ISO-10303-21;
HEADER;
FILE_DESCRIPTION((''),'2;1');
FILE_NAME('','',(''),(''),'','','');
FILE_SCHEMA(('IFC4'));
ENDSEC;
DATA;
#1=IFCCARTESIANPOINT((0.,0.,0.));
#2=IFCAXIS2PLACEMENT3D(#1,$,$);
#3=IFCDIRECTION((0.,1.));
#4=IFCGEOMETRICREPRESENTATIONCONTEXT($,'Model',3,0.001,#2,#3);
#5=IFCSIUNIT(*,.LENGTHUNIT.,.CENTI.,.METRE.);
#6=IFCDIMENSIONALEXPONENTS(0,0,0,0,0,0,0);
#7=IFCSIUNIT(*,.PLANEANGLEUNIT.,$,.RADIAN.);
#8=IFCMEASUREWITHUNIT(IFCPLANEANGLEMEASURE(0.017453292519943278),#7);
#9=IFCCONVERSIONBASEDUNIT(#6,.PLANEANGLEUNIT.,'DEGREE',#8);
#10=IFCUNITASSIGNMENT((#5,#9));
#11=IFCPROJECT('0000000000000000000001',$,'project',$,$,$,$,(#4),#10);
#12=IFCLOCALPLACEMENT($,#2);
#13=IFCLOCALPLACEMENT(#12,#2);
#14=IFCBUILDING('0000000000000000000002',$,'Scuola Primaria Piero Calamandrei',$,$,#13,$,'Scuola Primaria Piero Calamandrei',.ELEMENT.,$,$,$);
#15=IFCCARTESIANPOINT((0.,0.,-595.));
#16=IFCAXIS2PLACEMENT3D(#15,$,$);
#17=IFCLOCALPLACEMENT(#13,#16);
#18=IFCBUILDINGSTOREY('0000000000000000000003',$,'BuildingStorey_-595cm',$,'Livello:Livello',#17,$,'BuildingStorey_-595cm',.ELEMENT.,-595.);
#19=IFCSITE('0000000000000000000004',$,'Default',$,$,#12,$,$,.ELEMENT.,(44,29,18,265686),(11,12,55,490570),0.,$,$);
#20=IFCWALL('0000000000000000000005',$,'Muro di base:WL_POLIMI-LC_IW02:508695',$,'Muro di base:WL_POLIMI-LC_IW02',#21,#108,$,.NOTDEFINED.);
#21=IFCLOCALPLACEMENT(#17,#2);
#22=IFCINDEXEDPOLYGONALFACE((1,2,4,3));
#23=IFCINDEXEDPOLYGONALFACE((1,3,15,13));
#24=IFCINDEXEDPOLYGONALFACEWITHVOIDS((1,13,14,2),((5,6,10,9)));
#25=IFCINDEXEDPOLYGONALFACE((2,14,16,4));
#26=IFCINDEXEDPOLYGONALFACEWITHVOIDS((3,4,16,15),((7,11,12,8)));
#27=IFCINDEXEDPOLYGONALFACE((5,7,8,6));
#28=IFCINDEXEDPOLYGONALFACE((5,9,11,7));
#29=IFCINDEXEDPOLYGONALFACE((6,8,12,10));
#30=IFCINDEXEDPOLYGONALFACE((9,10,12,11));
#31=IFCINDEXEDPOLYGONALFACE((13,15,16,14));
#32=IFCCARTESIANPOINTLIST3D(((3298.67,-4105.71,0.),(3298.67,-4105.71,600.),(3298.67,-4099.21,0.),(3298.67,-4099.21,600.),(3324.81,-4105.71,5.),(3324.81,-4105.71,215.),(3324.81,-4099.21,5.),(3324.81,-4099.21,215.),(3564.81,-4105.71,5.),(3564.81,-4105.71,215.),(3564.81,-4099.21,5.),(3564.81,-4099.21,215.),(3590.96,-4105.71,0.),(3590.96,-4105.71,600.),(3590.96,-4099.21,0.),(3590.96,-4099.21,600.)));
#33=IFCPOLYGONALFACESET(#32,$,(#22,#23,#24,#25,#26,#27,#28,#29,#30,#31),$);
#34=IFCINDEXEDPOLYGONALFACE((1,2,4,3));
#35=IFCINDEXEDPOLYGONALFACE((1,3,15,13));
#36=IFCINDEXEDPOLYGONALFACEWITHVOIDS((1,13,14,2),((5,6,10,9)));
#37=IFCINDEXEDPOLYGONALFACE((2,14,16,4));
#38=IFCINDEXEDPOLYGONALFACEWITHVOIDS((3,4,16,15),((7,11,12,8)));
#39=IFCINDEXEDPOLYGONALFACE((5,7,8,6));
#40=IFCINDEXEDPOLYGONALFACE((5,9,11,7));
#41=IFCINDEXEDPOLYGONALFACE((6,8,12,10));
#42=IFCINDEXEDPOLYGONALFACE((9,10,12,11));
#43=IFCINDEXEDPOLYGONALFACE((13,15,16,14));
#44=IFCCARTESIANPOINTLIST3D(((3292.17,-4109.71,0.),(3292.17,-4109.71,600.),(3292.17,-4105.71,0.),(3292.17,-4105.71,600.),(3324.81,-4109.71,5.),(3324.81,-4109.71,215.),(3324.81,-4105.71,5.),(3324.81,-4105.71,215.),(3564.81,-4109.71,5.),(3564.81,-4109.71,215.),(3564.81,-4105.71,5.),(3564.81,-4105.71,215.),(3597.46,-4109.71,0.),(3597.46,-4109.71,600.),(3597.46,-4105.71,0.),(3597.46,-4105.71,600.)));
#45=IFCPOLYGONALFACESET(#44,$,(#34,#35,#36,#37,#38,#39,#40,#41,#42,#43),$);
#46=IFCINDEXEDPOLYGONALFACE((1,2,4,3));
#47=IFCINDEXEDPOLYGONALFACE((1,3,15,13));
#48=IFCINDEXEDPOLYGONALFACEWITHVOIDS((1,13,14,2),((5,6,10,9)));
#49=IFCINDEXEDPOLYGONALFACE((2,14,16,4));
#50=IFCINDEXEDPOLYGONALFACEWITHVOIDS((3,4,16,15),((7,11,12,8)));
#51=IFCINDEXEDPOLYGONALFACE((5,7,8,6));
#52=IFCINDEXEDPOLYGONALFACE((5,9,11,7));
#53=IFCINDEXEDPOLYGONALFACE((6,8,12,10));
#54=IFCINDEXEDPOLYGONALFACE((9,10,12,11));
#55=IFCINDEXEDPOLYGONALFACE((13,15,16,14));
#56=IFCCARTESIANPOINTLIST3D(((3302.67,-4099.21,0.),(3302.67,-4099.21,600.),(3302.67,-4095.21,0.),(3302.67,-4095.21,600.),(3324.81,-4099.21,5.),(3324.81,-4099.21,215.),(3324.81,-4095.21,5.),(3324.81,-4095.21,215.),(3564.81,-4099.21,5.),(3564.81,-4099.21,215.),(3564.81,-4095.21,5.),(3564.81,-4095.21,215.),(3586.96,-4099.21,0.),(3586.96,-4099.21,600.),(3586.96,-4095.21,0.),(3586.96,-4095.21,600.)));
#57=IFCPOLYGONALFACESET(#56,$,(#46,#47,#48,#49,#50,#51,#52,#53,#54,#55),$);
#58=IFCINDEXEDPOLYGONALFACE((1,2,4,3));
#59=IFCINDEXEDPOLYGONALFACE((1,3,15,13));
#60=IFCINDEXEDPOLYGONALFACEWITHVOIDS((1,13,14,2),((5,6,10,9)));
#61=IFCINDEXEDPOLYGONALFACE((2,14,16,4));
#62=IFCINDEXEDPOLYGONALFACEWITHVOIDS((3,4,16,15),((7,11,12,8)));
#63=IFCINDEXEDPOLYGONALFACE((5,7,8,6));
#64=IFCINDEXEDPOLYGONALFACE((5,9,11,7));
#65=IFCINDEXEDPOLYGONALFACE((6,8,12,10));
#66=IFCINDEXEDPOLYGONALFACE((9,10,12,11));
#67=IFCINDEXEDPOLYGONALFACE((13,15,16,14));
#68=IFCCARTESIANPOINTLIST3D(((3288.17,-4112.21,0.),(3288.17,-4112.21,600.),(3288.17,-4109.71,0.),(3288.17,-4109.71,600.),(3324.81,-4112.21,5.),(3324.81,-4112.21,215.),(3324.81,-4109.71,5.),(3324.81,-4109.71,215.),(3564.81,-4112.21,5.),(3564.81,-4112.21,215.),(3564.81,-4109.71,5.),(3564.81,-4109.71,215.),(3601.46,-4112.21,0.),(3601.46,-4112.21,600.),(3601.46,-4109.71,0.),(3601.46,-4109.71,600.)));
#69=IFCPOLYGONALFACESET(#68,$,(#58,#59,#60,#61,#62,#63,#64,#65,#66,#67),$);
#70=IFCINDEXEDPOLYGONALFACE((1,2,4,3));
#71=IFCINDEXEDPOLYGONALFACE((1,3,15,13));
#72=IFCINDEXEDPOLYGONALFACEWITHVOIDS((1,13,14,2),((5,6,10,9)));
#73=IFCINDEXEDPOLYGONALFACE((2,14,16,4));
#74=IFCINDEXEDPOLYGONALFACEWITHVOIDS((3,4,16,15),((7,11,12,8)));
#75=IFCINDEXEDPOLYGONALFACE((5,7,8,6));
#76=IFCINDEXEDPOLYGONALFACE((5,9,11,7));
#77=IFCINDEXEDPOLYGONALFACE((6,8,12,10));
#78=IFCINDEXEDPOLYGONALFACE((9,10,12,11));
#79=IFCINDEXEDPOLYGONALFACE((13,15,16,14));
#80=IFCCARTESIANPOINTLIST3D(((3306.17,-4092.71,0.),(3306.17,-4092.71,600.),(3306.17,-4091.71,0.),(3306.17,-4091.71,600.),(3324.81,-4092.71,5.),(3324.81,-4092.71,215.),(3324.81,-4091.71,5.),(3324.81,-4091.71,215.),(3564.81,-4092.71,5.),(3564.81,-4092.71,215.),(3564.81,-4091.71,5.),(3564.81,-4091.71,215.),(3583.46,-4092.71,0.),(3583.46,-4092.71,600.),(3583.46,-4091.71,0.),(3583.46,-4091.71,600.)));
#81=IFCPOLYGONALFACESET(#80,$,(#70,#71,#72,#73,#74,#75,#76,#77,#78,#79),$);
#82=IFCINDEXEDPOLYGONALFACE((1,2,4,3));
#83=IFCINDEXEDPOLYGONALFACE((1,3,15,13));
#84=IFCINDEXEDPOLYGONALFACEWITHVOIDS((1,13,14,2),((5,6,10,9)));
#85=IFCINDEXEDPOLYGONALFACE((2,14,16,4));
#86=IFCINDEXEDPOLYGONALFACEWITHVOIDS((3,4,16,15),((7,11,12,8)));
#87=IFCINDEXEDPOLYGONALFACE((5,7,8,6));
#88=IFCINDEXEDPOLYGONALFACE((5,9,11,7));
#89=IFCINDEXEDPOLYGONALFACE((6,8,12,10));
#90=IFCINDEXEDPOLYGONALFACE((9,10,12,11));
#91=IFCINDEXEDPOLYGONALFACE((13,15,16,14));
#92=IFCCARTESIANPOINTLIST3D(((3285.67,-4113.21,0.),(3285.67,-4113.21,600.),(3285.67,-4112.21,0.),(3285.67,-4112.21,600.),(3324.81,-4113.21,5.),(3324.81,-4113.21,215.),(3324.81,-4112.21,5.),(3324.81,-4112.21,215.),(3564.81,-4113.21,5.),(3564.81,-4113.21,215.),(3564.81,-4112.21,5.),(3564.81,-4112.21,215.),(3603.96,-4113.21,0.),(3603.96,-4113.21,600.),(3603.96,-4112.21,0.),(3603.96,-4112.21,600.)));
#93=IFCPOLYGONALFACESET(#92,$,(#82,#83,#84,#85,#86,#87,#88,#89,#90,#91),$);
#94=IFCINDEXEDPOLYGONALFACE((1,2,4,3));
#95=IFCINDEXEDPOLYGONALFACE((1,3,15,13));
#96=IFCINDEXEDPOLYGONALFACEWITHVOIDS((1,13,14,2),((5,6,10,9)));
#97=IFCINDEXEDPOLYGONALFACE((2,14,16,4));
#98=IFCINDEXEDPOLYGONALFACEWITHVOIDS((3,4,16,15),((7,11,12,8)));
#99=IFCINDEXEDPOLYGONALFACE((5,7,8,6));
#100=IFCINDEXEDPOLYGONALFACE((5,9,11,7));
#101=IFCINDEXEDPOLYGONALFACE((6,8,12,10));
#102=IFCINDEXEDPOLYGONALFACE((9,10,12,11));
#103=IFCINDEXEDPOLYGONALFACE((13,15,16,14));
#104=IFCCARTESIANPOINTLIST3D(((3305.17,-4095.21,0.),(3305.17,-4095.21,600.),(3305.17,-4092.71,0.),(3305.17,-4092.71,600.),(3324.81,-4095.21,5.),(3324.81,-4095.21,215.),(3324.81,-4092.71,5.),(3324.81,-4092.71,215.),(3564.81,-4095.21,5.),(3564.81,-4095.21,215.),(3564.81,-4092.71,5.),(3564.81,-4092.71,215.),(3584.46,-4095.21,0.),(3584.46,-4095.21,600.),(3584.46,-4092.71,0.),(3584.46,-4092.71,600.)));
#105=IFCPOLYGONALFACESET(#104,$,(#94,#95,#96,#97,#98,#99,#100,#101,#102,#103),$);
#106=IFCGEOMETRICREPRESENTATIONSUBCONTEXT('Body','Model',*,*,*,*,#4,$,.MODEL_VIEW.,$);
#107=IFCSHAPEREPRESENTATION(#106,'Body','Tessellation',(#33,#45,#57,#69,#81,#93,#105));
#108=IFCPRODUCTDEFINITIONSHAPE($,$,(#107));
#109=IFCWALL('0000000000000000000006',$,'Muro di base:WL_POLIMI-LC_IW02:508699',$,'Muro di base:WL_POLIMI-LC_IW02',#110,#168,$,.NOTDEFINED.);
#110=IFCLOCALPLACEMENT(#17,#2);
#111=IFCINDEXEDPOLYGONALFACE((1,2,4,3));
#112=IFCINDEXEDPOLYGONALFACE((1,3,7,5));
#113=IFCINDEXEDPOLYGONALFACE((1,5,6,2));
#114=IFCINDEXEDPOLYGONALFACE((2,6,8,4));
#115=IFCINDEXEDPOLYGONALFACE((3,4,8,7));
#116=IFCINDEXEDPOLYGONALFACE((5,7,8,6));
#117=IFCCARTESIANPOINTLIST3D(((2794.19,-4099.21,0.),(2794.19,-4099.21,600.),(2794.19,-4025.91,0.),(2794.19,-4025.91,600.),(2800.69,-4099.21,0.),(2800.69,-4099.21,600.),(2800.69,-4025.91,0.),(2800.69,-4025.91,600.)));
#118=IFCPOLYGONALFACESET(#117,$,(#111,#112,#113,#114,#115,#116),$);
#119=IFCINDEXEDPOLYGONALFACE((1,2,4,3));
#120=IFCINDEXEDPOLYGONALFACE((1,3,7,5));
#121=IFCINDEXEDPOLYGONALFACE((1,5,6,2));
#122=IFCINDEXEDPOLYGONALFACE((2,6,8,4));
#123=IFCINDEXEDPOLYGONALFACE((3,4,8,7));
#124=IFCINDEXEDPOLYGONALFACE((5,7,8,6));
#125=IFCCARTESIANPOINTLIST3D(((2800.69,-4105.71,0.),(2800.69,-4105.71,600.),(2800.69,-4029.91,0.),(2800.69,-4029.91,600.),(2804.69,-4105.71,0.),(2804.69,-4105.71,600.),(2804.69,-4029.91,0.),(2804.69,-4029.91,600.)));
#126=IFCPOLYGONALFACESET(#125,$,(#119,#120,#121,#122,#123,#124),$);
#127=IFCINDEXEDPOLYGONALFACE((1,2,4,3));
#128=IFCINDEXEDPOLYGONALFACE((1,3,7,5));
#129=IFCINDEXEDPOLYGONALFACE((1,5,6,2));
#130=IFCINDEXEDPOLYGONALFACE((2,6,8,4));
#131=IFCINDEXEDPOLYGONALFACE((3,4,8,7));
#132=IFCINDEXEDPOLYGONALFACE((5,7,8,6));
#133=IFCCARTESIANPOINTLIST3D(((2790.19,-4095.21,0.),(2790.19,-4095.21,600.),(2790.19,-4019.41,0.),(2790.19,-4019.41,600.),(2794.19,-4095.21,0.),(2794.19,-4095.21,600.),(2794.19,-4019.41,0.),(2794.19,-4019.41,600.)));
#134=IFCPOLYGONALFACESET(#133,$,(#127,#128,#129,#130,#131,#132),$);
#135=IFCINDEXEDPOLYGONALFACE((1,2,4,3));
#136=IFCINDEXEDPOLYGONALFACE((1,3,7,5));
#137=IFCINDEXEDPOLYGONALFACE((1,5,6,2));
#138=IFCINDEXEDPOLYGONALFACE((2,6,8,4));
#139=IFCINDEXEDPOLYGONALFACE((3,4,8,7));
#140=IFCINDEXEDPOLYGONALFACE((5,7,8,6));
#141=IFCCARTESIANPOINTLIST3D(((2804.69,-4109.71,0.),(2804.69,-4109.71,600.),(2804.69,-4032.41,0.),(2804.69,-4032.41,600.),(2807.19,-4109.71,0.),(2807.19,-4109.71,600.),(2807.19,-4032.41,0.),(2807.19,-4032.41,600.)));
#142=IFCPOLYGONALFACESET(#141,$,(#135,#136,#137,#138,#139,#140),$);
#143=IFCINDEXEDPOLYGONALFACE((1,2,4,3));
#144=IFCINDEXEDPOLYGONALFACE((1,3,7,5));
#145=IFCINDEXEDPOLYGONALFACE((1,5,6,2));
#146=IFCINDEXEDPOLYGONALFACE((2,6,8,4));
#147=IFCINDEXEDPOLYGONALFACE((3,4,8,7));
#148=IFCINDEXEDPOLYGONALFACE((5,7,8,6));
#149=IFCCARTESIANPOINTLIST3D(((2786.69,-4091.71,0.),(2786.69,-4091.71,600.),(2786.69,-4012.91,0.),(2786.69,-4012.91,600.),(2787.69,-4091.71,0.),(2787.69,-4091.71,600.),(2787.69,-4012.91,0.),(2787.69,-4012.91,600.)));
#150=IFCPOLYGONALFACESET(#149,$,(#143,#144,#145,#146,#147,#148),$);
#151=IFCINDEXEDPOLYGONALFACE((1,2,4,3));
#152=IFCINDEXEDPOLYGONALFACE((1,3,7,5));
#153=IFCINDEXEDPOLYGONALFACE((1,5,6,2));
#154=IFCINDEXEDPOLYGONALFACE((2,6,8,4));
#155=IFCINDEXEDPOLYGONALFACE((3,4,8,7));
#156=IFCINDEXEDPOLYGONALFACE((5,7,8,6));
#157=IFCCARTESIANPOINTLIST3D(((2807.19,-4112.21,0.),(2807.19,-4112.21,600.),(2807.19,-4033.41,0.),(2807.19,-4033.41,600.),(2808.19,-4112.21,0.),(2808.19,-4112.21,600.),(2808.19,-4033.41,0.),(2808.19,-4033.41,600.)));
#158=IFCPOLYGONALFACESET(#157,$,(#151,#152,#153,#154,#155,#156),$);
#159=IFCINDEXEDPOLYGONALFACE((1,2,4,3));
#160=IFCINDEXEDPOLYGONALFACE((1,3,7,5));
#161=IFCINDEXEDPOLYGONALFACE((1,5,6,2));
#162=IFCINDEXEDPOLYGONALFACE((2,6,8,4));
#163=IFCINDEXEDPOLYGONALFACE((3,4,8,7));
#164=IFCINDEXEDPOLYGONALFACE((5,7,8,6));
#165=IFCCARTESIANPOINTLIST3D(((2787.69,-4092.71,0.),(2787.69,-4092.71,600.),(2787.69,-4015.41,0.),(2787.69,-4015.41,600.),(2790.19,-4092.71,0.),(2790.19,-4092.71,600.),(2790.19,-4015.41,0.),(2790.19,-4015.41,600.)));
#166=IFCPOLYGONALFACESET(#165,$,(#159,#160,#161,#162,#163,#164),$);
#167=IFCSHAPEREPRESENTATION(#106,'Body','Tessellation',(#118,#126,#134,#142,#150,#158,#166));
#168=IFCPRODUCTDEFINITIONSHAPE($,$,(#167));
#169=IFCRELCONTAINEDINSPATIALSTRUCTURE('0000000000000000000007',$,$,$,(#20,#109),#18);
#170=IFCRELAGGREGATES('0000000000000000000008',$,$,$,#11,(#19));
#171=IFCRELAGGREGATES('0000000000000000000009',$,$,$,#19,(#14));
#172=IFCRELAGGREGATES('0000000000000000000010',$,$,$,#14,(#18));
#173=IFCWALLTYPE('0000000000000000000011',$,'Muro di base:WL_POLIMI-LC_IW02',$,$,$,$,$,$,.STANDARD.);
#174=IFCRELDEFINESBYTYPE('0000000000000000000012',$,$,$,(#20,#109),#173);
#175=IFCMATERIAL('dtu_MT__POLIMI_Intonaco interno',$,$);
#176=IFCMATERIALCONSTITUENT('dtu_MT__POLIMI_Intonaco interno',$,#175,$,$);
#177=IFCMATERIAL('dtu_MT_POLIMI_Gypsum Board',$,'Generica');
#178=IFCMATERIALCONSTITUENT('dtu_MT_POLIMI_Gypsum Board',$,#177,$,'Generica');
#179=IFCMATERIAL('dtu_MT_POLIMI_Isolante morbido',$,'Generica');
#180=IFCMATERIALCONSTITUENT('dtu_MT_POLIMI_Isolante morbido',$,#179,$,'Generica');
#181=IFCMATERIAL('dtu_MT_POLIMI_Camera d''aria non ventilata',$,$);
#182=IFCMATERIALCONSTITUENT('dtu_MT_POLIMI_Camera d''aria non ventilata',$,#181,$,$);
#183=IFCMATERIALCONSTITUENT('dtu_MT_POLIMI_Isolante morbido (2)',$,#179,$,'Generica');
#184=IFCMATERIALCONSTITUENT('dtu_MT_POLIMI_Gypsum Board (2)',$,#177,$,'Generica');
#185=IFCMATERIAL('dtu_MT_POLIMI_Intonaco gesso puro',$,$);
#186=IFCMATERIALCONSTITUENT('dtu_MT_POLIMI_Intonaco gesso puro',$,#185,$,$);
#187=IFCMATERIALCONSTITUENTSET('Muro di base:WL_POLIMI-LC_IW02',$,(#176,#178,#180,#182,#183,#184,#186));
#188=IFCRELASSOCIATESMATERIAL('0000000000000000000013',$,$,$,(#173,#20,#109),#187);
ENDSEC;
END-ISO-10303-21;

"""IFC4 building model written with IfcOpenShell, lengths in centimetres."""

from ifc_helpers import new_model, entity, si_unit, converted_unit, direction, frame, origin, place, context, subcontext, project, spatial, indexed_curve, outline, extrude, material, constituent, constituent_set, type_object, element, save


model = new_model("IFC4")

# Units and contexts
model_context = context("Model", 3, precision=0.001, world=origin(), true_north=direction((0.0, 1.0)))
body_context = subcontext(model_context, "Body", "Model", "MODEL_VIEW")
ifc_project = project(units=[si_unit("LENGTHUNIT", "METRE", prefix="CENTI"), converted_unit("PLANEANGLEUNIT", "DEGREE", entity("IfcPlaneAngleMeasure", 0.017453292519943278), si_unit("PLANEANGLEUNIT", "RADIAN"), dimensions=[0, 0, 0, 0, 0, 0, 0])], contexts=[model_context])

# Site, building, storey
site_placement = place(None, origin())
site = spatial("IfcSite", under=ifc_project, at=site_placement, Name="Default", CompositionType="ELEMENT", RefLatitude=(44, 29, 18, 265686), RefLongitude=(11, 12, 55, 490570), RefElevation=0.0)
building_placement = place(site_placement, origin())
building = spatial("IfcBuilding", under=site, at=building_placement, Name="Scuola Primaria Piero Calamandrei", LongName="Scuola Primaria Piero Calamandrei", CompositionType="ELEMENT")
storey_placement = place(building_placement, frame((0.0, 0.0, -595.0)))
storey = spatial("IfcBuildingStorey", under=building, at=storey_placement, Name="BuildingStorey_-595cm", ObjectType="Livello:Livello", LongName="BuildingStorey_-595cm", CompositionType="ELEMENT", Elevation=-595.0)

# Shared definitions
ifc_material_1 = material(Name="dtu_MT__POLIMI_Intonaco interno")
ifc_constituent_1 = constituent(ifc_material_1, Name="dtu_MT__POLIMI_Intonaco interno")
ifc_material_2 = material(Name="dtu_MT_POLIMI_Gypsum Board", Category="Generica")
ifc_constituent_2 = constituent(ifc_material_2, Name="dtu_MT_POLIMI_Gypsum Board", Category="Generica")
ifc_material_3 = material(Name="dtu_MT_POLIMI_Isolante morbido", Category="Generica")
ifc_constituent_3 = constituent(ifc_material_3, Name="dtu_MT_POLIMI_Isolante morbido", Category="Generica")
ifc_material_4 = material(Name="dtu_MT_POLIMI_Camera d'aria non ventilata")
ifc_constituent_4 = constituent(ifc_material_4, Name="dtu_MT_POLIMI_Camera d'aria non ventilata")
ifc_constituent_5 = constituent(ifc_material_3, Name="dtu_MT_POLIMI_Isolante morbido (2)", Category="Generica")
ifc_constituent_6 = constituent(ifc_material_2, Name="dtu_MT_POLIMI_Gypsum Board (2)", Category="Generica")
ifc_material_5 = material(Name="dtu_MT_POLIMI_Intonaco gesso puro")
ifc_constituent_7 = constituent(ifc_material_5, Name="dtu_MT_POLIMI_Intonaco gesso puro")
ifc_constituent_set_1 = constituent_set(constituents=[ifc_constituent_1, ifc_constituent_2, ifc_constituent_3, ifc_constituent_4, ifc_constituent_5, ifc_constituent_6, ifc_constituent_7], Name="Muro di base:WL_POLIMI-LC_IW02")
wall_type_1 = type_object("IfcWallType", Name="Muro di base:WL_POLIMI-LC_IW02", PredefinedType="STANDARD", material=ifc_constituent_set_1)

# Wall, opening
wall_1_placement = place(storey_placement, frame((3583.46, -4102.46, 0.0), z_axis=(0.0, 0.0, 1.0), x_axis=(-1.0, 0.0, 0.0)))
wall_1 = element("IfcWall", 1, at=wall_1_placement, inside=storey, type_object=wall_type_1, material=ifc_constituent_set_1, Name="Muro di base:WL_POLIMI-LC_IW02:508695", ObjectType="Muro di base:WL_POLIMI-LC_IW02", PredefinedType="NOTDEFINED", context=body_context, shape_type="SweptSolid", body=[
    extrude(outline(indexed_curve([(-300.0, -146.14), (300.0, -146.14), (300.0, 146.14), (-300.0, 146.14), (-300.0, -146.14)], self_intersect=False), holes=[indexed_curve([(-85.0, 120.0), (-85.0, -120.0), (-295.0, -120.0), (-295.0, 120.0), (-85.0, 120.0)], self_intersect=False)]), frame((138.64, 3.25, 300.0), z_axis=(0.0, -1.0, 0.0), x_axis=(0.0, 0.0, 1.0)), (0.0, 0.0, 1.0), 6.5),
    extrude(outline(indexed_curve([(-300.0, -152.64), (300.0, -152.64), (300.0, 152.64), (-300.0, 152.64), (-300.0, -152.64)], self_intersect=False), holes=[indexed_curve([(-85.0, 120.0), (-85.0, -120.0), (-295.0, -120.0), (-295.0, 120.0), (-85.0, 120.0)], self_intersect=False)]), frame((138.64, 7.25, 300.0), z_axis=(0.0, -1.0, 0.0), x_axis=(0.0, 0.0, 1.0)), (0.0, 0.0, 1.0), 4.0),
    extrude(outline(indexed_curve([(-300.0, -142.14), (300.0, -142.14), (300.0, 142.14), (-300.0, 142.14), (-300.0, -142.14)], self_intersect=False), holes=[indexed_curve([(-85.0, 120.0), (-85.0, -120.0), (-295.0, -120.0), (-295.0, 120.0), (-85.0, 120.0)], self_intersect=False)]), frame((138.64, -3.25, 300.0), z_axis=(0.0, -1.0, 0.0), x_axis=(0.0, 0.0, 1.0)), (0.0, 0.0, 1.0), 4.0),
    extrude(outline(indexed_curve([(-300.0, -156.64), (300.0, -156.64), (300.0, 156.64), (-300.0, 156.64), (-300.0, -156.64)], self_intersect=False), holes=[indexed_curve([(-85.0, 120.0), (-85.0, -120.0), (-295.0, -120.0), (-295.0, 120.0), (-85.0, 120.0)], self_intersect=False)]), frame((138.64, 9.75, 300.0), z_axis=(0.0, -1.0, 0.0), x_axis=(0.0, 0.0, 1.0)), (0.0, 0.0, 1.0), 2.5),
    extrude(outline(indexed_curve([(-300.0, -138.64), (300.0, -138.64), (300.0, 138.64), (-300.0, 138.64), (-300.0, -138.64)], self_intersect=False), holes=[indexed_curve([(-85.0, 120.0), (-85.0, -120.0), (-295.0, -120.0), (-295.0, 120.0), (-85.0, 120.0)], self_intersect=False)]), frame((138.64, -9.75, 300.0), z_axis=(0.0, -1.0, 0.0), x_axis=(0.0, 0.0, 1.0)), (0.0, 0.0, 1.0), 1.0),
    extrude(outline(indexed_curve([(-300.0, -159.14), (300.0, -159.14), (300.0, 159.14), (-300.0, 159.14), (-300.0, -159.14)], self_intersect=False), holes=[indexed_curve([(-85.0, 120.0), (-85.0, -120.0), (-295.0, -120.0), (-295.0, 120.0), (-85.0, 120.0)], self_intersect=False)]), frame((138.64, 10.75, 300.0), z_axis=(0.0, -1.0, 0.0), x_axis=(0.0, 0.0, 1.0)), (0.0, 0.0, 1.0), 1.0),
    extrude(outline(indexed_curve([(-300.0, -139.64), (300.0, -139.64), (300.0, 139.64), (-300.0, 139.64), (-300.0, -139.64)], self_intersect=False), holes=[indexed_curve([(-85.0, 120.0), (-85.0, -120.0), (-295.0, -120.0), (-295.0, 120.0), (-85.0, 120.0)], self_intersect=False)]), frame((138.64, -7.25, 300.0), z_axis=(0.0, -1.0, 0.0), x_axis=(0.0, 0.0, 1.0)), (0.0, 0.0, 1.0), 2.5),
])
opening_1_placement = place(wall_1_placement, frame((258.64, 10.75, 5.0)))
element("IfcOpeningElement", 2, at=opening_1_placement, cuts=wall_1, PredefinedType="OPENING", context=body_context, shape_type="SweptSolid", body=[
    extrude(outline(indexed_curve([(210.0, 240.0), (0.0, 240.0), (0.0, 0.0), (210.0, 0.0), (210.0, 240.0)], self_intersect=False)), frame((0.0, 0.0, 0.0), z_axis=(0.0, -1.0, 0.0), x_axis=(0.0, 0.0, 1.0)), (0.0, 0.0, 1.0), 21.5),
])

# Wall
wall_2_placement = place(storey_placement, frame((2797.44, -4033.41, 0.0), z_axis=(0.0, 0.0, 1.0), x_axis=(0.0, -1.0, 0.0)))
element("IfcWall", 3, at=wall_2_placement, inside=storey, type_object=wall_type_1, material=ifc_constituent_set_1, Name="Muro di base:WL_POLIMI-LC_IW02:508699", ObjectType="Muro di base:WL_POLIMI-LC_IW02", PredefinedType="NOTDEFINED", context=body_context, shape_type="SweptSolid", body=[
    extrude(outline(indexed_curve([(-36.65, -3.25), (36.65, -3.25), (36.65, 3.25), (-36.65, 3.25), (-36.65, -3.25)], self_intersect=False)), frame((29.15, 0.0, 0.0)), (0.0, 0.0, 1.0), 600.0),
    extrude(outline(indexed_curve([(-37.9, -2.0), (37.9, -2.0), (37.9, 2.0), (-37.9, 2.0), (-37.9, -2.0)], self_intersect=False)), frame((34.4, 5.25, 0.0)), (0.0, 0.0, 1.0), 600.0),
    extrude(outline(indexed_curve([(-37.9, -2.0), (37.9, -2.0), (37.9, 2.0), (-37.9, 2.0), (-37.9, -2.0)], self_intersect=False)), frame((23.9, -5.25, 0.0)), (0.0, 0.0, 1.0), 600.0),
    extrude(outline(indexed_curve([(-38.65, -1.25), (38.65, -1.25), (38.65, 1.25), (-38.65, 1.25), (-38.65, -1.25)], self_intersect=False)), frame((37.65, 8.5, 0.0)), (0.0, 0.0, 1.0), 600.0),
    extrude(outline(indexed_curve([(-0.5, -39.4), (0.5, -39.4), (0.5, 39.4), (-0.5, 39.4), (-0.5, -39.4)], self_intersect=False)), frame((18.9, -10.25, 0.0), z_axis=(0.0, 0.0, 1.0), x_axis=(0.0, 1.0, 0.0)), (0.0, 0.0, 1.0), 600.0),
    extrude(outline(indexed_curve([(-0.5, -39.4), (0.5, -39.4), (0.5, 39.4), (-0.5, 39.4), (-0.5, -39.4)], self_intersect=False)), frame((39.4, 10.25, 0.0), z_axis=(0.0, 0.0, 1.0), x_axis=(0.0, -1.0, 0.0)), (0.0, 0.0, 1.0), 600.0),
    extrude(outline(indexed_curve([(-38.65, -1.25), (38.65, -1.25), (38.65, 1.25), (-38.65, 1.25), (-38.65, -1.25)], self_intersect=False)), frame((20.65, -8.5, 0.0)), (0.0, 0.0, 1.0), 600.0),
])

save(model, "model.ifc")
